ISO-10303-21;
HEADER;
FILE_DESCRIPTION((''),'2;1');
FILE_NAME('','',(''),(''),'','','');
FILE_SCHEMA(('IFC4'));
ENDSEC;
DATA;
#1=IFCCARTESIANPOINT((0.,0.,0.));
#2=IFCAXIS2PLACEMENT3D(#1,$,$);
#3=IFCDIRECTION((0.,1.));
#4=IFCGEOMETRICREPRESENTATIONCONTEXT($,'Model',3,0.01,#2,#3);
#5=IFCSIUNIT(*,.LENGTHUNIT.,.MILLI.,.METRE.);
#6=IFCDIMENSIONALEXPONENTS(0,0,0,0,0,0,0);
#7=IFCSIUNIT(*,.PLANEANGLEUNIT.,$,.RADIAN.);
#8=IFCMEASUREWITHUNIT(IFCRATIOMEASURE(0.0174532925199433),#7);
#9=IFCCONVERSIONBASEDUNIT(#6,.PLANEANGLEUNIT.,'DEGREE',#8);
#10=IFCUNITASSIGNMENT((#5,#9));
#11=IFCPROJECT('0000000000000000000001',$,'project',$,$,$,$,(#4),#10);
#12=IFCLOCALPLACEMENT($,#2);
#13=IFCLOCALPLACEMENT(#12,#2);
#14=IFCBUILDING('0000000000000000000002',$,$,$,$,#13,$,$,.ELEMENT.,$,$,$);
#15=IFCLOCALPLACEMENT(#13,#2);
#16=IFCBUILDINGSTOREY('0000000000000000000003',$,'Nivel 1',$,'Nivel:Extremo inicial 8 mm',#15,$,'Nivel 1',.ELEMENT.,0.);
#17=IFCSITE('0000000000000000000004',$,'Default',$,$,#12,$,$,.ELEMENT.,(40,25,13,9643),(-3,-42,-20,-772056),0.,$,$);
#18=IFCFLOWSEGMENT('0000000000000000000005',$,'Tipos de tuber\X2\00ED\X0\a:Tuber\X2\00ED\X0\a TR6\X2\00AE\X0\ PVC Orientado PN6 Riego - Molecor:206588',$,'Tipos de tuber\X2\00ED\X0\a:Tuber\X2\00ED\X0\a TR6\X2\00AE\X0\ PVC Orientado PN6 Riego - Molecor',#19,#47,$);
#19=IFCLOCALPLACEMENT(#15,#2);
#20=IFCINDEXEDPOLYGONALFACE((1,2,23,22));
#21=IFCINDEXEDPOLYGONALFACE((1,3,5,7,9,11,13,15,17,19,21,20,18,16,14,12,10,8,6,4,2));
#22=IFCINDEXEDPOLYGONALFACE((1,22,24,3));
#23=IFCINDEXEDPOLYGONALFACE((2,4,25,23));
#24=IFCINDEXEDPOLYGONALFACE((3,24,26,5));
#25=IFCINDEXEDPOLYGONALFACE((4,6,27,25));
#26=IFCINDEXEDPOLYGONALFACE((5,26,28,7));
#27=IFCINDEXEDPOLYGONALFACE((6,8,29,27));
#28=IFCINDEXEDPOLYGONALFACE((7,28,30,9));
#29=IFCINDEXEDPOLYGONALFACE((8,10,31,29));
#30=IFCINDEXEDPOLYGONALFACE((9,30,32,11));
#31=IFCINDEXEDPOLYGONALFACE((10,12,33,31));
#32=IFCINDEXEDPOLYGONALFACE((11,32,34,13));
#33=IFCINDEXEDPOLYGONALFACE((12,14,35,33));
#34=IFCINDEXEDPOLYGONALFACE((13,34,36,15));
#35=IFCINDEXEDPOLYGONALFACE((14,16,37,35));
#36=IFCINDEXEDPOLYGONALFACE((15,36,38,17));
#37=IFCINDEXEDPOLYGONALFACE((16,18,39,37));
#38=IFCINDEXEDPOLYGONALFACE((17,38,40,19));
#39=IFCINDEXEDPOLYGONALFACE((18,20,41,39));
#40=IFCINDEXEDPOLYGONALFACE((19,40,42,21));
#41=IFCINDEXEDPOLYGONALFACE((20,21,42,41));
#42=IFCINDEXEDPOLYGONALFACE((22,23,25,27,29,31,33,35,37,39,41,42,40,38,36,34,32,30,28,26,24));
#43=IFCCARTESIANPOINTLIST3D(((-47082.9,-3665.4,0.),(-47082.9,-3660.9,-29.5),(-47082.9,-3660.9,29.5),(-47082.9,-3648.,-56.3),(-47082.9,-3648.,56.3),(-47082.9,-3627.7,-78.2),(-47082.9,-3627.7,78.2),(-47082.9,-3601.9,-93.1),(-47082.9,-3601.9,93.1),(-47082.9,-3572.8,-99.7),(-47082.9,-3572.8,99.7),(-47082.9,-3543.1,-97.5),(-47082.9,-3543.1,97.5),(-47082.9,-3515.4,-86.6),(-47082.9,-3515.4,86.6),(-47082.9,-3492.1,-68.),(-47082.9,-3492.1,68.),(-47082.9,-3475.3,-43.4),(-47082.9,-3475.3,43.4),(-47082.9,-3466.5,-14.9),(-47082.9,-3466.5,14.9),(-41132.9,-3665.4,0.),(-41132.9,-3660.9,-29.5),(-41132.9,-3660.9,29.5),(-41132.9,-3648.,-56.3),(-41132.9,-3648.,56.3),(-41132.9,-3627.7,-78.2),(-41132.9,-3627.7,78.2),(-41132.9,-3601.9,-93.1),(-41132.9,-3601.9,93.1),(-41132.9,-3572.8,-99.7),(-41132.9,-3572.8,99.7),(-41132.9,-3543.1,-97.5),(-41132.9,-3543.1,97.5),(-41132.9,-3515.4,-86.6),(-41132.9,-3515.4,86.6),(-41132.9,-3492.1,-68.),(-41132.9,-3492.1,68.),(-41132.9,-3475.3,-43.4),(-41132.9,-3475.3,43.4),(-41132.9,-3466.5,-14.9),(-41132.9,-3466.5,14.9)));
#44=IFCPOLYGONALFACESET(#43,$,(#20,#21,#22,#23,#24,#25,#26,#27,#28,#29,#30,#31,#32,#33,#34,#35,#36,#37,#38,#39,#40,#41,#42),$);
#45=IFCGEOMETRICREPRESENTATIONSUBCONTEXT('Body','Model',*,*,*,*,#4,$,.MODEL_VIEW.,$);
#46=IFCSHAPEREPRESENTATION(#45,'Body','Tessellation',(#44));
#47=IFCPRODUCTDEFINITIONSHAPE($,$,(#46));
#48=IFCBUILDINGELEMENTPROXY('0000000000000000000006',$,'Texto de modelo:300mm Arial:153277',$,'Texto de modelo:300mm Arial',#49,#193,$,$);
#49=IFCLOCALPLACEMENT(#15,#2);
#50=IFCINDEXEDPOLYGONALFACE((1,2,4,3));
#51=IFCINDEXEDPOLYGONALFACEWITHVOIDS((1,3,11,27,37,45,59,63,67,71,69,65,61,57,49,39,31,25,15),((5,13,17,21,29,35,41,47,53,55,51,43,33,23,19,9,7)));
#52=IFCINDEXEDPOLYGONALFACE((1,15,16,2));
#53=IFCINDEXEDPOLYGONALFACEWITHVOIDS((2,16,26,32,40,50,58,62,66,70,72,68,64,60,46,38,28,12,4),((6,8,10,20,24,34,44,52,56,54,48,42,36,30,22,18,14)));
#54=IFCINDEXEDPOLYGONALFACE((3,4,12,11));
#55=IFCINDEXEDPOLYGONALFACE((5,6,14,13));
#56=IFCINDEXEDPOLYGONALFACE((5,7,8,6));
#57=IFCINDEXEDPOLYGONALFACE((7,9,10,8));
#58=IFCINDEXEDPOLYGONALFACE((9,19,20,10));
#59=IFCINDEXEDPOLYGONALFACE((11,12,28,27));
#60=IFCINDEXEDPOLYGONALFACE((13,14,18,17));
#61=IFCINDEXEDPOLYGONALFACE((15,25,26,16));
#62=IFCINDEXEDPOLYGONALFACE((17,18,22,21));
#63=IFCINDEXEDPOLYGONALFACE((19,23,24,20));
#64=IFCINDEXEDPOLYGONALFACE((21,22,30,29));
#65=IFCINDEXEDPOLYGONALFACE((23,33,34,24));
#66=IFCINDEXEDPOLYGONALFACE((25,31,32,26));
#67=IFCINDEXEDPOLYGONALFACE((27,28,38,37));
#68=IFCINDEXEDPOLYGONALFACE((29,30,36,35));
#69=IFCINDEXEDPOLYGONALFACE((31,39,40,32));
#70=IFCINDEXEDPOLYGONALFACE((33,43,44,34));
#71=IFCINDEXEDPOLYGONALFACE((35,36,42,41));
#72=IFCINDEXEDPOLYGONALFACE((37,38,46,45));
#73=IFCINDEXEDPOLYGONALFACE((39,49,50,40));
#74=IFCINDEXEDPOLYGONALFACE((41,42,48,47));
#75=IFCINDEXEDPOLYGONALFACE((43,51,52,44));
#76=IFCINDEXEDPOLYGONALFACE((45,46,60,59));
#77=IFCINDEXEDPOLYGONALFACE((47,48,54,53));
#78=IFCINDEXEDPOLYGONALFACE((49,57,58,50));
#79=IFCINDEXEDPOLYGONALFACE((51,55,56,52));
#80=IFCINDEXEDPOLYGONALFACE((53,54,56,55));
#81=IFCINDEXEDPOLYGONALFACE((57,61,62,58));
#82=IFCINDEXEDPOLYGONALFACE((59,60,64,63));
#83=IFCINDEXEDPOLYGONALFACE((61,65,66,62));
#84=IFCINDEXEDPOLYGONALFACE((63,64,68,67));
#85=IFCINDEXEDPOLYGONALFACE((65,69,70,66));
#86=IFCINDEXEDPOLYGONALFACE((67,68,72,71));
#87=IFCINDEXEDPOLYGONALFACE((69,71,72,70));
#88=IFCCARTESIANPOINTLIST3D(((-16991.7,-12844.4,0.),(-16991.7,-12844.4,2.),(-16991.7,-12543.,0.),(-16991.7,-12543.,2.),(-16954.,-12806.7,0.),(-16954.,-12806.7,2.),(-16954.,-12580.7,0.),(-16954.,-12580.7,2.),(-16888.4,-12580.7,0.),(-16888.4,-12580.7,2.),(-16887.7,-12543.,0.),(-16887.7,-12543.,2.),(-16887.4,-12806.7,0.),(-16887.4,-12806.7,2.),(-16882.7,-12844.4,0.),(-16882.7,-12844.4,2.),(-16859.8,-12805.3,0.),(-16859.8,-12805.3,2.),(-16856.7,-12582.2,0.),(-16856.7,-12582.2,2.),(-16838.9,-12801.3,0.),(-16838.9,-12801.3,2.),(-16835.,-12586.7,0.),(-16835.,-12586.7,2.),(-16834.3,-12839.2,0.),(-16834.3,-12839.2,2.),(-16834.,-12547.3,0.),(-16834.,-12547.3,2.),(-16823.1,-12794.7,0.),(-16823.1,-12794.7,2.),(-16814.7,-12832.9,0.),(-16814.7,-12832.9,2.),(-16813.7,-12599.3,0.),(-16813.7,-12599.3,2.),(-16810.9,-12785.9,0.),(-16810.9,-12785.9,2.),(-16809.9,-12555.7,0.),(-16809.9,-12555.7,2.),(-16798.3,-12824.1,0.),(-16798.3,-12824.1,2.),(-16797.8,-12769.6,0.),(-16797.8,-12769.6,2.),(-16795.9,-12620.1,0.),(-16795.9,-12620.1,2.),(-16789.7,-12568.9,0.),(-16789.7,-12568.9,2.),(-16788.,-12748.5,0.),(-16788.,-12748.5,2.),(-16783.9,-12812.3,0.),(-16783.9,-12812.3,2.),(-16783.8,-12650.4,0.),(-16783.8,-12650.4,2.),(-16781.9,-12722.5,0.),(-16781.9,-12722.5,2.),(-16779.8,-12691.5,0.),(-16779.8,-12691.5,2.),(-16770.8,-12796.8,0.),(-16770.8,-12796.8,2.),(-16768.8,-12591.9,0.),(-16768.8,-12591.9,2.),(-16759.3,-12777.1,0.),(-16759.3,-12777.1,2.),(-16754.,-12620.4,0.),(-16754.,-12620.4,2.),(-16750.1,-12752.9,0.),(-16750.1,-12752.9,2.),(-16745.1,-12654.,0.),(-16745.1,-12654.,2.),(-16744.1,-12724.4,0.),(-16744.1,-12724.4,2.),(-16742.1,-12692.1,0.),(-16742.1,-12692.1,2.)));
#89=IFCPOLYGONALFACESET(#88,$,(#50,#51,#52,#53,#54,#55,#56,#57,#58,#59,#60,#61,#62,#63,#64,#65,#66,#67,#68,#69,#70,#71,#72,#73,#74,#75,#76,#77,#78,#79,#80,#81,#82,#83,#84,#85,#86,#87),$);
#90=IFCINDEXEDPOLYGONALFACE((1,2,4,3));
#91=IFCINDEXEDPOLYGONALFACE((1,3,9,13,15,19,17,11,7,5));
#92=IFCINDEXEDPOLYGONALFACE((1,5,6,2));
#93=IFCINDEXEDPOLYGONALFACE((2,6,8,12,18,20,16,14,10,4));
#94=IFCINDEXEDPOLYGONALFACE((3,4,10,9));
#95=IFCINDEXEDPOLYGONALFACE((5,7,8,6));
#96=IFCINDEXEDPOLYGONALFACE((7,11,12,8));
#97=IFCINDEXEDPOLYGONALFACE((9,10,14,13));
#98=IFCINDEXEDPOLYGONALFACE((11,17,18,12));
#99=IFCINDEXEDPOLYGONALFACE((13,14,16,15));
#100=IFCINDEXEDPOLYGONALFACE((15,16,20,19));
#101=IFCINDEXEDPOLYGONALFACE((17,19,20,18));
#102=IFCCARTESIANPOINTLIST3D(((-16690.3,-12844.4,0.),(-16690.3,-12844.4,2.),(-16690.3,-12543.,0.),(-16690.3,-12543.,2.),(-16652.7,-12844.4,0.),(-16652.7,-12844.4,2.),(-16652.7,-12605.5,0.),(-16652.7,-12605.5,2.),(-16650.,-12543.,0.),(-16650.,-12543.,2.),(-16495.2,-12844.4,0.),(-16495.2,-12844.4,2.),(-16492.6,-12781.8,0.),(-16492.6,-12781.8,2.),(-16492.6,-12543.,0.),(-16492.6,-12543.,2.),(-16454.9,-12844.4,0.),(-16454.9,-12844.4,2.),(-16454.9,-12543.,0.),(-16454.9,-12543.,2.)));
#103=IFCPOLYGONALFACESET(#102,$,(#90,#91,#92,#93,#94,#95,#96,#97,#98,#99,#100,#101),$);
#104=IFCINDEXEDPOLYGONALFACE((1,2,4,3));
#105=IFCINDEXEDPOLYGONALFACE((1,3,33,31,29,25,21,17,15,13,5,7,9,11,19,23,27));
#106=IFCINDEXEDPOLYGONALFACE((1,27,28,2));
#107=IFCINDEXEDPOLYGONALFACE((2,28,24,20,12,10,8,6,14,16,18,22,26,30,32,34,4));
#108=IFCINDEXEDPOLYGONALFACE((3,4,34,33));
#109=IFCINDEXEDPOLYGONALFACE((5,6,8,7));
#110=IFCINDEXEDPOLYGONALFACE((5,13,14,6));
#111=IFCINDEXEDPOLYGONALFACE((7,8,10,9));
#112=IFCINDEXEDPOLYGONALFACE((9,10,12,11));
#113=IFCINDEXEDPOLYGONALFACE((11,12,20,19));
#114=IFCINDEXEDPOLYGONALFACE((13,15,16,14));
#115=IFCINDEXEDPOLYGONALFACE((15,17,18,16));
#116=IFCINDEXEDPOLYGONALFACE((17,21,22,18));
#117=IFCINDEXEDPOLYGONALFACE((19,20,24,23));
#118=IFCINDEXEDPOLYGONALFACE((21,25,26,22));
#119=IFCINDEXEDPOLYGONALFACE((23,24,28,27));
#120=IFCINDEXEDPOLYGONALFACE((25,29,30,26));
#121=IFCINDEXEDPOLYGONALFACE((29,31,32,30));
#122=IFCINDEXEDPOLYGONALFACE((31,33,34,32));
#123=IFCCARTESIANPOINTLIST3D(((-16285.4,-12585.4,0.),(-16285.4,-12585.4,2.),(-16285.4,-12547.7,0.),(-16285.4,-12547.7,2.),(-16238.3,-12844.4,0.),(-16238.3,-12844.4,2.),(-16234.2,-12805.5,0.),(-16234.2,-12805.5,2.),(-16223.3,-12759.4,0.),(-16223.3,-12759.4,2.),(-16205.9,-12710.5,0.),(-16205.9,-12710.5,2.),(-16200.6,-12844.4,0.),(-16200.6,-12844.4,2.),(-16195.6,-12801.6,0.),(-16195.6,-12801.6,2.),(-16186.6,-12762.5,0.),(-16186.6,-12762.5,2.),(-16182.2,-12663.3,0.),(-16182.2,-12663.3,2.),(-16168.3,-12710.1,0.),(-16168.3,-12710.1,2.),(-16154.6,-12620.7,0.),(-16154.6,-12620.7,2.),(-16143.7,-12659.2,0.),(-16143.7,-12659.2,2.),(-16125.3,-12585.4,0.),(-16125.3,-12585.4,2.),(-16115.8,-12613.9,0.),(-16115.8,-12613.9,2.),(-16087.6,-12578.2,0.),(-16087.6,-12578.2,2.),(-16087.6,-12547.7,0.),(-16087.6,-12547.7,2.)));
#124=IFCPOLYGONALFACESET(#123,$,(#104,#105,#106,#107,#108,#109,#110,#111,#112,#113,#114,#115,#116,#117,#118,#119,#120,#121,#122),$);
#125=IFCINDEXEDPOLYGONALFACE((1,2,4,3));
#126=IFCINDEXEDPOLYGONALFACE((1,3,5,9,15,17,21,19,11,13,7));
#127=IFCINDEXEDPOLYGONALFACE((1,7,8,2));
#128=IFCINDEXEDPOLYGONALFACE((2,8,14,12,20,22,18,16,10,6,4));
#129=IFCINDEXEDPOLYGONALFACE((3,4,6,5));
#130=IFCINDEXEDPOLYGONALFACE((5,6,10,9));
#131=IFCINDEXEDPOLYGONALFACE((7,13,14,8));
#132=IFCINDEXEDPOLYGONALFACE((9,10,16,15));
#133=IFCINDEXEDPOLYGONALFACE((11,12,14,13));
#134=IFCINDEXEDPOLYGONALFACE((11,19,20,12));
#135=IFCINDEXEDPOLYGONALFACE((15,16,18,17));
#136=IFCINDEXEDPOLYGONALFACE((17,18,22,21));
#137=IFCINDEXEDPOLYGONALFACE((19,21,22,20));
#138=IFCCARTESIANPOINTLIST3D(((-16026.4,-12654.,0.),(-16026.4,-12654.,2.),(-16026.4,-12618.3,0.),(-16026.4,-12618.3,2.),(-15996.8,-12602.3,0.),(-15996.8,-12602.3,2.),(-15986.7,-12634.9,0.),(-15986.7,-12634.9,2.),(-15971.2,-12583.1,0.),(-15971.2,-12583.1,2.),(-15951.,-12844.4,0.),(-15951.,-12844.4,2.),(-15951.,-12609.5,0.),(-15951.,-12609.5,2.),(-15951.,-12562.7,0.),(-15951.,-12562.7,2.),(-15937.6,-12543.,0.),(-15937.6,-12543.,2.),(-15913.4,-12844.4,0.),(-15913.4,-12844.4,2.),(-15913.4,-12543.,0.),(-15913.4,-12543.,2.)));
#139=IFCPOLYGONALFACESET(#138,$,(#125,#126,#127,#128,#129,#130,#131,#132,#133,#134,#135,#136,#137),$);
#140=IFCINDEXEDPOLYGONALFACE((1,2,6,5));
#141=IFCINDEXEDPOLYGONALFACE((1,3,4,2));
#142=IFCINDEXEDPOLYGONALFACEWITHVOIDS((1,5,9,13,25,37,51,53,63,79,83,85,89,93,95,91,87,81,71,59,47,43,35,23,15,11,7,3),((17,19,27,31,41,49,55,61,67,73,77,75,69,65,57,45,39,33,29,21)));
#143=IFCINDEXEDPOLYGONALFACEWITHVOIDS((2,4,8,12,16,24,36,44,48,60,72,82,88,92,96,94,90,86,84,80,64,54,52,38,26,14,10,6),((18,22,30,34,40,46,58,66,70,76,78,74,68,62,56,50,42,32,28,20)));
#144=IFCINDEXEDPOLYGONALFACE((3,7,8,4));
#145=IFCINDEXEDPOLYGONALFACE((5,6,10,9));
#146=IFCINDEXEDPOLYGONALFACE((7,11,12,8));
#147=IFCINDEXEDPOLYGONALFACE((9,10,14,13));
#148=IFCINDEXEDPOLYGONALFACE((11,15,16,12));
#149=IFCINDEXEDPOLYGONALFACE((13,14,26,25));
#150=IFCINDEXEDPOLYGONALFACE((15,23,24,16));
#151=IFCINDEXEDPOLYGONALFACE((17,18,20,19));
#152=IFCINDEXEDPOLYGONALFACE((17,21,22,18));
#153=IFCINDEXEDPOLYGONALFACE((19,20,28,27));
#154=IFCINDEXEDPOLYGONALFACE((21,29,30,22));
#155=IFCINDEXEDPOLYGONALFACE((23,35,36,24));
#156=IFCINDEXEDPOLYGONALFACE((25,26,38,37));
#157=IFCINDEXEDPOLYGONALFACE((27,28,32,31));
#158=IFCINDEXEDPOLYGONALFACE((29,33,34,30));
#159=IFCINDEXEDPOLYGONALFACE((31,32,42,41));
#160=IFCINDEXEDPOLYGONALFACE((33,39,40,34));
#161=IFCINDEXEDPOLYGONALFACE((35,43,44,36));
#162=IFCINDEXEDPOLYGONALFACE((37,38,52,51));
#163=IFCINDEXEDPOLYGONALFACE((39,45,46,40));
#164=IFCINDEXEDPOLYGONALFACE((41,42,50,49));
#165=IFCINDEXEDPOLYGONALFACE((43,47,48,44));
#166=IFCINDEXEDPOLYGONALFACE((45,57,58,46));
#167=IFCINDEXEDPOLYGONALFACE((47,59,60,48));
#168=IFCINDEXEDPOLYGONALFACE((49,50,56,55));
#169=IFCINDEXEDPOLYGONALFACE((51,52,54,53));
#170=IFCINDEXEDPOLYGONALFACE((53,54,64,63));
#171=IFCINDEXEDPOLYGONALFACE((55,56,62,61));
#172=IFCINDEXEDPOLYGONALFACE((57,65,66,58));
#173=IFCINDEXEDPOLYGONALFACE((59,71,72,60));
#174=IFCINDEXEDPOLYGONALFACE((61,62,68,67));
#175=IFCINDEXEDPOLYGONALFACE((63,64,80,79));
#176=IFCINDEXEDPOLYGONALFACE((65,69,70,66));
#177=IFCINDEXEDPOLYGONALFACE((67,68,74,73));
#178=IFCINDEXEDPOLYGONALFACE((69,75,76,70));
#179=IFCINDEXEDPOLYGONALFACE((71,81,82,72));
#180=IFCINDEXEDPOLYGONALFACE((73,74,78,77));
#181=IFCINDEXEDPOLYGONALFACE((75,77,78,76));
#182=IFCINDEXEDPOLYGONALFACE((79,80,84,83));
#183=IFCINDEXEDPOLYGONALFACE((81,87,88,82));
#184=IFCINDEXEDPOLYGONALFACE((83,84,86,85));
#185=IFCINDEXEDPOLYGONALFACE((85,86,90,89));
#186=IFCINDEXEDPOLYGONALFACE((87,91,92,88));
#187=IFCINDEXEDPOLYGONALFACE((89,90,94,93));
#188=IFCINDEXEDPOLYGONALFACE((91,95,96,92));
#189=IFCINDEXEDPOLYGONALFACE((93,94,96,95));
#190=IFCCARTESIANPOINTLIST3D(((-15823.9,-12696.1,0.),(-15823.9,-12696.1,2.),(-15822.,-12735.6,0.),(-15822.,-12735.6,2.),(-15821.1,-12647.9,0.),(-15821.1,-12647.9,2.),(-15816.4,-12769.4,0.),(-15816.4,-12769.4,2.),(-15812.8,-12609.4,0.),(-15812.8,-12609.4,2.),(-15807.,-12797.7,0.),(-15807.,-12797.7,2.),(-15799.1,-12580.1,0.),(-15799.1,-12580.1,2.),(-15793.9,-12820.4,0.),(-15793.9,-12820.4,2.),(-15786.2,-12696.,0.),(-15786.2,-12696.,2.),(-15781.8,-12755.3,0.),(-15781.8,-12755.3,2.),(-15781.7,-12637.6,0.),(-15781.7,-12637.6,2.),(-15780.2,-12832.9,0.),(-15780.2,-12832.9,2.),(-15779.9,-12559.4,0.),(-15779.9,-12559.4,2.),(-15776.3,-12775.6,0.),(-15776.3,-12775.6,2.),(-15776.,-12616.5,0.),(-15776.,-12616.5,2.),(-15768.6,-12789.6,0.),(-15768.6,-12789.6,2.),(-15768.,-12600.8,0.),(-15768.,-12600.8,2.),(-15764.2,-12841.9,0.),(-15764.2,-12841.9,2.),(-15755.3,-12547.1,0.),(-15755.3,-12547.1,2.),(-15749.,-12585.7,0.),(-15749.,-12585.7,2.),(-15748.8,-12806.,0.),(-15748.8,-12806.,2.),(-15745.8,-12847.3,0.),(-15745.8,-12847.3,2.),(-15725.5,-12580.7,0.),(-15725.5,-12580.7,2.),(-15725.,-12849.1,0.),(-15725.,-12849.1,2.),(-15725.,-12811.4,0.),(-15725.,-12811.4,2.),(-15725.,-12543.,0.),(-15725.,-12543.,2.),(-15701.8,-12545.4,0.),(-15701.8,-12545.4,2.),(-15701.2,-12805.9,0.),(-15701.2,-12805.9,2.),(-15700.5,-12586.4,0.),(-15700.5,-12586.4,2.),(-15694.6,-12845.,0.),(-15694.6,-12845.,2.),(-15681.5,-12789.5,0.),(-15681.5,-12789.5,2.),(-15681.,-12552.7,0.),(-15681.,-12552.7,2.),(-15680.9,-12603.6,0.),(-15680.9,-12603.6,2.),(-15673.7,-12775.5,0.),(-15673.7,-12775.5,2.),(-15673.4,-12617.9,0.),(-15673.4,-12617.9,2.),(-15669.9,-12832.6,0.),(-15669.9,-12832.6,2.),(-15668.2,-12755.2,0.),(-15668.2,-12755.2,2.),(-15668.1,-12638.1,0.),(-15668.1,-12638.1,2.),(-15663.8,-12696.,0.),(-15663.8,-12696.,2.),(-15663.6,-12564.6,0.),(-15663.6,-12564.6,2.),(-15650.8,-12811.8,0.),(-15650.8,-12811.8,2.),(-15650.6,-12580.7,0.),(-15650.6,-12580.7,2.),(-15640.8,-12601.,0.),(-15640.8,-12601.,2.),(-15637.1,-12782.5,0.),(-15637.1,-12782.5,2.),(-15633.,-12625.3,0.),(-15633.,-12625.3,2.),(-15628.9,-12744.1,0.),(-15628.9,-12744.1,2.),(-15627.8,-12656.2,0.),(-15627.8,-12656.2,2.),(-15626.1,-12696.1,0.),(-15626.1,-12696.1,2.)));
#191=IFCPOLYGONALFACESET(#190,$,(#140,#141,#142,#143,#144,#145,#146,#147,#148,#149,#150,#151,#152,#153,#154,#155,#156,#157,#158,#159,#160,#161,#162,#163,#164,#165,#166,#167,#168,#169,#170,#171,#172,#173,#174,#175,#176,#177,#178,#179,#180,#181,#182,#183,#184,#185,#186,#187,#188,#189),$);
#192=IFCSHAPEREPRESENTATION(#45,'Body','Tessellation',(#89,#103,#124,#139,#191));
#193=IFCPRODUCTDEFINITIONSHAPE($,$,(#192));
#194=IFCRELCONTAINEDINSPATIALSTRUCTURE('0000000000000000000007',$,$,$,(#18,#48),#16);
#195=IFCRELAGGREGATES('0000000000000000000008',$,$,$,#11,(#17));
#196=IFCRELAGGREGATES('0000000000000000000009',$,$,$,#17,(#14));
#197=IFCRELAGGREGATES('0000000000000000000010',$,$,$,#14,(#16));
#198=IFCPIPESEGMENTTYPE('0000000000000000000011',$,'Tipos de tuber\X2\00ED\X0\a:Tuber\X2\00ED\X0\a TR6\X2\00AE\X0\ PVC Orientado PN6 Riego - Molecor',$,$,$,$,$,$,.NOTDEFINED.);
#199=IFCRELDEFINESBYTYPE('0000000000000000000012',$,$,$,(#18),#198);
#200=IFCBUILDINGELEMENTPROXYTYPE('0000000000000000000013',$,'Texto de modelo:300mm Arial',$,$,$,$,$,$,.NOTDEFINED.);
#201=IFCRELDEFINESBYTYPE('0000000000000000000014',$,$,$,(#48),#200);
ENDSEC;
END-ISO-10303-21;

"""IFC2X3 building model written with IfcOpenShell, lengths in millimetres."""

from ifc_helpers import new_model, entity, si_unit, converted_unit, direction, frame, frame_2d, origin, place, context, subcontext, project, spatial, polyline, circle, outline, extrude, type_object, element, save


model = new_model("IFC2X3")

# Units and contexts
model_context = context("Model", 3, precision=0.01, world=origin(), true_north=direction((0.0, 1.0)))
body_context = subcontext(model_context, "Body", "Model", "MODEL_VIEW")
ifc_project = project(units=[si_unit("LENGTHUNIT", "METRE", prefix="MILLI"), converted_unit("PLANEANGLEUNIT", "DEGREE", entity("IfcRatioMeasure", 0.0174532925199433), si_unit("PLANEANGLEUNIT", "RADIAN"), dimensions=[0, 0, 0, 0, 0, 0, 0])], contexts=[model_context])

# Site, building, storey
site_placement = place(None, origin())
site = spatial("IfcSite", under=ifc_project, at=site_placement, Name="Default", CompositionType="ELEMENT", RefLatitude=(40, 25, 13, 9643), RefLongitude=(-3, -42, -20, -772056), RefElevation=0.0)
building_placement = place(site_placement, origin())
building = spatial("IfcBuilding", under=site, at=building_placement, CompositionType="ELEMENT")
storey_placement = place(building_placement, origin())
storey = spatial("IfcBuildingStorey", under=building, at=storey_placement, Name="Nivel 1", ObjectType="Nivel:Extremo inicial 8 mm", LongName="Nivel 1", CompositionType="ELEMENT", Elevation=0.0)

# Flow segment
pipe_segment_type = type_object("IfcPipeSegmentType", Name="Tipos de tubería:Tubería TR6® PVC Orientado PN6 Riego - Molecor", PredefinedType="NOTDEFINED")
flow_segment_1_placement = place(storey_placement, frame((-47082.9, -3667.0, -101.6)))
element("IfcFlowSegment", 1, at=flow_segment_1_placement, inside=storey, type_object=pipe_segment_type, Name="Tipos de tubería:Tubería TR6® PVC Orientado PN6 Riego - Molecor:206588", ObjectType="Tipos de tubería:Tubería TR6® PVC Orientado PN6 Riego - Molecor", context=body_context, shape_type="SweptSolid", body=[
    extrude(circle(Radius=100.0, at=frame_2d((0.0, 0.0), x_axis=(1.0, 0.0))), frame((0.0, 101.6, 101.6), z_axis=(1.0, 0.0, 0.0), x_axis=(0.0, -1.0, 0.0)), (0.0, 0.0, 1.0), 5950.0),
])

# Building element proxy
building_element_proxy_type_1 = type_object("IfcBuildingElementProxyType", Name="Texto de modelo:300mm Arial", PredefinedType="NOTDEFINED")
proxy_1_placement = place(storey_placement, frame((-16991.7, -12849.1, 0.0)))
element("IfcBuildingElementProxy", 2, at=proxy_1_placement, inside=storey, type_object=building_element_proxy_type_1, Name="Texto de modelo:300mm Arial:153277", ObjectType="Texto de modelo:300mm Arial", context=body_context, shape_type="SweptSolid", body=[
    extrude(outline(polyline([(-178.4, -141.0), (-69.4, -141.0), (-21.0, -135.8), (-1.4, -129.5), (15.0, -120.7), (29.4, -108.9), (42.6, -93.4), (54.0, -73.7), (63.2, -49.5), (69.2, -21.0), (71.2, 11.3), (68.2, 49.4), (59.3, 83.0), (44.5, 111.5), (23.7, 134.5), (3.4, 147.7), (-20.6, 156.1), (-74.4, 160.4), (-178.4, 160.4), (-178.4, -141.0)]), holes=[polyline([(-140.7, -103.3), (-140.7, 122.7), (-75.1, 122.7), (-43.3, 121.2), (-21.7, 116.7), (-0.4, 104.1), (17.4, 83.3), (29.5, 53.0), (33.5, 11.9), (31.5, -19.1), (25.3, -45.1), (15.5, -66.2), (2.4, -82.5), (-9.8, -91.3), (-25.6, -97.9), (-46.5, -101.9), (-74.1, -103.3), (-140.7, -103.3)])]), frame((178.4, 145.7, 0.0)), (0.0, 0.0, 1.0), 2.0),
    extrude(outline(polyline([(-117.7, -150.7), (-80.1, -150.7), (-80.1, 88.1), (77.4, -150.7), (117.7, -150.7), (117.7, 150.7), (80.1, 150.7), (80.1, -88.1), (-77.4, 150.7), (-117.7, 150.7), (-117.7, -150.7)])), frame((419.1, 155.4, 0.0)), (0.0, 0.0, 1.0), 2.0),
    extrude(outline(polyline([(-101.8, -99.3), (-101.8, -137.0), (96.0, -137.0), (96.0, -106.5), (67.8, -70.9), (39.9, -25.5), (15.2, 25.4), (-3.1, 77.8), (-12.1, 116.9), (-17.1, 159.7), (-54.7, 159.7), (-50.7, 120.8), (-39.8, 74.7), (-22.3, 25.8), (1.3, -21.4), (29.0, -64.0), (58.3, -99.3), (-101.8, -99.3)])), frame((808.2, 164.4, 0.0), z_axis=(0.0, 0.0, -1.0), x_axis=(1.0, 0.0, 0.0)), (0.0, 0.0, -1.0), 2.0),
    extrude(outline(polyline([(-204.4, -52.5), (97.0, -52.5), (97.0, -28.2), (77.2, -14.9), (56.9, 5.3), (37.7, 30.9), (21.6, 60.5), (-14.0, 60.5), (5.0, 20.8), (30.4, -14.9), (-204.4, -14.9), (-204.4, -52.5)])), frame((1025.8, 209.1, 0.0), z_axis=(0.0, 0.0, 1.0), x_axis=(0.0, 1.0, 0.0)), (0.0, 0.0, 1.0), 2.0),
    extrude(outline(polyline([(-5.6, -99.5), (33.9, -99.5), (68.0, -95.5), (96.7, -87.5), (120.0, -75.5), (133.2, -62.4), (142.9, -46.8), (149.1, -28.7), (151.9, -8.0), (149.2, 22.6), (138.0, 47.8), (118.2, 67.9), (89.5, 82.9), (51.6, 93.0), (3.8, 98.0), (-36.2, 98.2), (-67.3, 94.5), (-91.9, 87.9), (-112.6, 79.0), (-129.4, 66.8), (-142.0, 50.0), (-150.3, 29.6), (-153.8, 6.5), (-151.2, -23.9), (-140.1, -49.1), (-120.3, -69.2), (-91.7, -84.4), (-53.6, -94.5), (-5.6, -99.5)]), holes=[polyline([(-3.9, -61.9), (-62.1, -54.6), (-82.9, -47.9), (-98.1, -39.2), (-112.3, -19.5), (-116.2, 4.3), (-109.3, 28.9), (-91.2, 47.7), (-76.5, 54.5), (-56.1, 58.9), (1.9, 60.4), (60.8, 53.2), (80.8, 46.7), (94.5, 38.3), (109.9, 17.8), (114.3, -6.3), (107.7, -29.8), (90.4, -48.7), (76.0, -55.8), (55.5, -60.3), (-3.9, -61.9)])]), frame((1267.5, 152.1, 0.0), z_axis=(0.0, 0.0, 1.0), x_axis=(0.047515, -0.998871, 0.0)), (0.0, 0.0, 1.0), 2.0),
])

save(model, "model.ifc")
